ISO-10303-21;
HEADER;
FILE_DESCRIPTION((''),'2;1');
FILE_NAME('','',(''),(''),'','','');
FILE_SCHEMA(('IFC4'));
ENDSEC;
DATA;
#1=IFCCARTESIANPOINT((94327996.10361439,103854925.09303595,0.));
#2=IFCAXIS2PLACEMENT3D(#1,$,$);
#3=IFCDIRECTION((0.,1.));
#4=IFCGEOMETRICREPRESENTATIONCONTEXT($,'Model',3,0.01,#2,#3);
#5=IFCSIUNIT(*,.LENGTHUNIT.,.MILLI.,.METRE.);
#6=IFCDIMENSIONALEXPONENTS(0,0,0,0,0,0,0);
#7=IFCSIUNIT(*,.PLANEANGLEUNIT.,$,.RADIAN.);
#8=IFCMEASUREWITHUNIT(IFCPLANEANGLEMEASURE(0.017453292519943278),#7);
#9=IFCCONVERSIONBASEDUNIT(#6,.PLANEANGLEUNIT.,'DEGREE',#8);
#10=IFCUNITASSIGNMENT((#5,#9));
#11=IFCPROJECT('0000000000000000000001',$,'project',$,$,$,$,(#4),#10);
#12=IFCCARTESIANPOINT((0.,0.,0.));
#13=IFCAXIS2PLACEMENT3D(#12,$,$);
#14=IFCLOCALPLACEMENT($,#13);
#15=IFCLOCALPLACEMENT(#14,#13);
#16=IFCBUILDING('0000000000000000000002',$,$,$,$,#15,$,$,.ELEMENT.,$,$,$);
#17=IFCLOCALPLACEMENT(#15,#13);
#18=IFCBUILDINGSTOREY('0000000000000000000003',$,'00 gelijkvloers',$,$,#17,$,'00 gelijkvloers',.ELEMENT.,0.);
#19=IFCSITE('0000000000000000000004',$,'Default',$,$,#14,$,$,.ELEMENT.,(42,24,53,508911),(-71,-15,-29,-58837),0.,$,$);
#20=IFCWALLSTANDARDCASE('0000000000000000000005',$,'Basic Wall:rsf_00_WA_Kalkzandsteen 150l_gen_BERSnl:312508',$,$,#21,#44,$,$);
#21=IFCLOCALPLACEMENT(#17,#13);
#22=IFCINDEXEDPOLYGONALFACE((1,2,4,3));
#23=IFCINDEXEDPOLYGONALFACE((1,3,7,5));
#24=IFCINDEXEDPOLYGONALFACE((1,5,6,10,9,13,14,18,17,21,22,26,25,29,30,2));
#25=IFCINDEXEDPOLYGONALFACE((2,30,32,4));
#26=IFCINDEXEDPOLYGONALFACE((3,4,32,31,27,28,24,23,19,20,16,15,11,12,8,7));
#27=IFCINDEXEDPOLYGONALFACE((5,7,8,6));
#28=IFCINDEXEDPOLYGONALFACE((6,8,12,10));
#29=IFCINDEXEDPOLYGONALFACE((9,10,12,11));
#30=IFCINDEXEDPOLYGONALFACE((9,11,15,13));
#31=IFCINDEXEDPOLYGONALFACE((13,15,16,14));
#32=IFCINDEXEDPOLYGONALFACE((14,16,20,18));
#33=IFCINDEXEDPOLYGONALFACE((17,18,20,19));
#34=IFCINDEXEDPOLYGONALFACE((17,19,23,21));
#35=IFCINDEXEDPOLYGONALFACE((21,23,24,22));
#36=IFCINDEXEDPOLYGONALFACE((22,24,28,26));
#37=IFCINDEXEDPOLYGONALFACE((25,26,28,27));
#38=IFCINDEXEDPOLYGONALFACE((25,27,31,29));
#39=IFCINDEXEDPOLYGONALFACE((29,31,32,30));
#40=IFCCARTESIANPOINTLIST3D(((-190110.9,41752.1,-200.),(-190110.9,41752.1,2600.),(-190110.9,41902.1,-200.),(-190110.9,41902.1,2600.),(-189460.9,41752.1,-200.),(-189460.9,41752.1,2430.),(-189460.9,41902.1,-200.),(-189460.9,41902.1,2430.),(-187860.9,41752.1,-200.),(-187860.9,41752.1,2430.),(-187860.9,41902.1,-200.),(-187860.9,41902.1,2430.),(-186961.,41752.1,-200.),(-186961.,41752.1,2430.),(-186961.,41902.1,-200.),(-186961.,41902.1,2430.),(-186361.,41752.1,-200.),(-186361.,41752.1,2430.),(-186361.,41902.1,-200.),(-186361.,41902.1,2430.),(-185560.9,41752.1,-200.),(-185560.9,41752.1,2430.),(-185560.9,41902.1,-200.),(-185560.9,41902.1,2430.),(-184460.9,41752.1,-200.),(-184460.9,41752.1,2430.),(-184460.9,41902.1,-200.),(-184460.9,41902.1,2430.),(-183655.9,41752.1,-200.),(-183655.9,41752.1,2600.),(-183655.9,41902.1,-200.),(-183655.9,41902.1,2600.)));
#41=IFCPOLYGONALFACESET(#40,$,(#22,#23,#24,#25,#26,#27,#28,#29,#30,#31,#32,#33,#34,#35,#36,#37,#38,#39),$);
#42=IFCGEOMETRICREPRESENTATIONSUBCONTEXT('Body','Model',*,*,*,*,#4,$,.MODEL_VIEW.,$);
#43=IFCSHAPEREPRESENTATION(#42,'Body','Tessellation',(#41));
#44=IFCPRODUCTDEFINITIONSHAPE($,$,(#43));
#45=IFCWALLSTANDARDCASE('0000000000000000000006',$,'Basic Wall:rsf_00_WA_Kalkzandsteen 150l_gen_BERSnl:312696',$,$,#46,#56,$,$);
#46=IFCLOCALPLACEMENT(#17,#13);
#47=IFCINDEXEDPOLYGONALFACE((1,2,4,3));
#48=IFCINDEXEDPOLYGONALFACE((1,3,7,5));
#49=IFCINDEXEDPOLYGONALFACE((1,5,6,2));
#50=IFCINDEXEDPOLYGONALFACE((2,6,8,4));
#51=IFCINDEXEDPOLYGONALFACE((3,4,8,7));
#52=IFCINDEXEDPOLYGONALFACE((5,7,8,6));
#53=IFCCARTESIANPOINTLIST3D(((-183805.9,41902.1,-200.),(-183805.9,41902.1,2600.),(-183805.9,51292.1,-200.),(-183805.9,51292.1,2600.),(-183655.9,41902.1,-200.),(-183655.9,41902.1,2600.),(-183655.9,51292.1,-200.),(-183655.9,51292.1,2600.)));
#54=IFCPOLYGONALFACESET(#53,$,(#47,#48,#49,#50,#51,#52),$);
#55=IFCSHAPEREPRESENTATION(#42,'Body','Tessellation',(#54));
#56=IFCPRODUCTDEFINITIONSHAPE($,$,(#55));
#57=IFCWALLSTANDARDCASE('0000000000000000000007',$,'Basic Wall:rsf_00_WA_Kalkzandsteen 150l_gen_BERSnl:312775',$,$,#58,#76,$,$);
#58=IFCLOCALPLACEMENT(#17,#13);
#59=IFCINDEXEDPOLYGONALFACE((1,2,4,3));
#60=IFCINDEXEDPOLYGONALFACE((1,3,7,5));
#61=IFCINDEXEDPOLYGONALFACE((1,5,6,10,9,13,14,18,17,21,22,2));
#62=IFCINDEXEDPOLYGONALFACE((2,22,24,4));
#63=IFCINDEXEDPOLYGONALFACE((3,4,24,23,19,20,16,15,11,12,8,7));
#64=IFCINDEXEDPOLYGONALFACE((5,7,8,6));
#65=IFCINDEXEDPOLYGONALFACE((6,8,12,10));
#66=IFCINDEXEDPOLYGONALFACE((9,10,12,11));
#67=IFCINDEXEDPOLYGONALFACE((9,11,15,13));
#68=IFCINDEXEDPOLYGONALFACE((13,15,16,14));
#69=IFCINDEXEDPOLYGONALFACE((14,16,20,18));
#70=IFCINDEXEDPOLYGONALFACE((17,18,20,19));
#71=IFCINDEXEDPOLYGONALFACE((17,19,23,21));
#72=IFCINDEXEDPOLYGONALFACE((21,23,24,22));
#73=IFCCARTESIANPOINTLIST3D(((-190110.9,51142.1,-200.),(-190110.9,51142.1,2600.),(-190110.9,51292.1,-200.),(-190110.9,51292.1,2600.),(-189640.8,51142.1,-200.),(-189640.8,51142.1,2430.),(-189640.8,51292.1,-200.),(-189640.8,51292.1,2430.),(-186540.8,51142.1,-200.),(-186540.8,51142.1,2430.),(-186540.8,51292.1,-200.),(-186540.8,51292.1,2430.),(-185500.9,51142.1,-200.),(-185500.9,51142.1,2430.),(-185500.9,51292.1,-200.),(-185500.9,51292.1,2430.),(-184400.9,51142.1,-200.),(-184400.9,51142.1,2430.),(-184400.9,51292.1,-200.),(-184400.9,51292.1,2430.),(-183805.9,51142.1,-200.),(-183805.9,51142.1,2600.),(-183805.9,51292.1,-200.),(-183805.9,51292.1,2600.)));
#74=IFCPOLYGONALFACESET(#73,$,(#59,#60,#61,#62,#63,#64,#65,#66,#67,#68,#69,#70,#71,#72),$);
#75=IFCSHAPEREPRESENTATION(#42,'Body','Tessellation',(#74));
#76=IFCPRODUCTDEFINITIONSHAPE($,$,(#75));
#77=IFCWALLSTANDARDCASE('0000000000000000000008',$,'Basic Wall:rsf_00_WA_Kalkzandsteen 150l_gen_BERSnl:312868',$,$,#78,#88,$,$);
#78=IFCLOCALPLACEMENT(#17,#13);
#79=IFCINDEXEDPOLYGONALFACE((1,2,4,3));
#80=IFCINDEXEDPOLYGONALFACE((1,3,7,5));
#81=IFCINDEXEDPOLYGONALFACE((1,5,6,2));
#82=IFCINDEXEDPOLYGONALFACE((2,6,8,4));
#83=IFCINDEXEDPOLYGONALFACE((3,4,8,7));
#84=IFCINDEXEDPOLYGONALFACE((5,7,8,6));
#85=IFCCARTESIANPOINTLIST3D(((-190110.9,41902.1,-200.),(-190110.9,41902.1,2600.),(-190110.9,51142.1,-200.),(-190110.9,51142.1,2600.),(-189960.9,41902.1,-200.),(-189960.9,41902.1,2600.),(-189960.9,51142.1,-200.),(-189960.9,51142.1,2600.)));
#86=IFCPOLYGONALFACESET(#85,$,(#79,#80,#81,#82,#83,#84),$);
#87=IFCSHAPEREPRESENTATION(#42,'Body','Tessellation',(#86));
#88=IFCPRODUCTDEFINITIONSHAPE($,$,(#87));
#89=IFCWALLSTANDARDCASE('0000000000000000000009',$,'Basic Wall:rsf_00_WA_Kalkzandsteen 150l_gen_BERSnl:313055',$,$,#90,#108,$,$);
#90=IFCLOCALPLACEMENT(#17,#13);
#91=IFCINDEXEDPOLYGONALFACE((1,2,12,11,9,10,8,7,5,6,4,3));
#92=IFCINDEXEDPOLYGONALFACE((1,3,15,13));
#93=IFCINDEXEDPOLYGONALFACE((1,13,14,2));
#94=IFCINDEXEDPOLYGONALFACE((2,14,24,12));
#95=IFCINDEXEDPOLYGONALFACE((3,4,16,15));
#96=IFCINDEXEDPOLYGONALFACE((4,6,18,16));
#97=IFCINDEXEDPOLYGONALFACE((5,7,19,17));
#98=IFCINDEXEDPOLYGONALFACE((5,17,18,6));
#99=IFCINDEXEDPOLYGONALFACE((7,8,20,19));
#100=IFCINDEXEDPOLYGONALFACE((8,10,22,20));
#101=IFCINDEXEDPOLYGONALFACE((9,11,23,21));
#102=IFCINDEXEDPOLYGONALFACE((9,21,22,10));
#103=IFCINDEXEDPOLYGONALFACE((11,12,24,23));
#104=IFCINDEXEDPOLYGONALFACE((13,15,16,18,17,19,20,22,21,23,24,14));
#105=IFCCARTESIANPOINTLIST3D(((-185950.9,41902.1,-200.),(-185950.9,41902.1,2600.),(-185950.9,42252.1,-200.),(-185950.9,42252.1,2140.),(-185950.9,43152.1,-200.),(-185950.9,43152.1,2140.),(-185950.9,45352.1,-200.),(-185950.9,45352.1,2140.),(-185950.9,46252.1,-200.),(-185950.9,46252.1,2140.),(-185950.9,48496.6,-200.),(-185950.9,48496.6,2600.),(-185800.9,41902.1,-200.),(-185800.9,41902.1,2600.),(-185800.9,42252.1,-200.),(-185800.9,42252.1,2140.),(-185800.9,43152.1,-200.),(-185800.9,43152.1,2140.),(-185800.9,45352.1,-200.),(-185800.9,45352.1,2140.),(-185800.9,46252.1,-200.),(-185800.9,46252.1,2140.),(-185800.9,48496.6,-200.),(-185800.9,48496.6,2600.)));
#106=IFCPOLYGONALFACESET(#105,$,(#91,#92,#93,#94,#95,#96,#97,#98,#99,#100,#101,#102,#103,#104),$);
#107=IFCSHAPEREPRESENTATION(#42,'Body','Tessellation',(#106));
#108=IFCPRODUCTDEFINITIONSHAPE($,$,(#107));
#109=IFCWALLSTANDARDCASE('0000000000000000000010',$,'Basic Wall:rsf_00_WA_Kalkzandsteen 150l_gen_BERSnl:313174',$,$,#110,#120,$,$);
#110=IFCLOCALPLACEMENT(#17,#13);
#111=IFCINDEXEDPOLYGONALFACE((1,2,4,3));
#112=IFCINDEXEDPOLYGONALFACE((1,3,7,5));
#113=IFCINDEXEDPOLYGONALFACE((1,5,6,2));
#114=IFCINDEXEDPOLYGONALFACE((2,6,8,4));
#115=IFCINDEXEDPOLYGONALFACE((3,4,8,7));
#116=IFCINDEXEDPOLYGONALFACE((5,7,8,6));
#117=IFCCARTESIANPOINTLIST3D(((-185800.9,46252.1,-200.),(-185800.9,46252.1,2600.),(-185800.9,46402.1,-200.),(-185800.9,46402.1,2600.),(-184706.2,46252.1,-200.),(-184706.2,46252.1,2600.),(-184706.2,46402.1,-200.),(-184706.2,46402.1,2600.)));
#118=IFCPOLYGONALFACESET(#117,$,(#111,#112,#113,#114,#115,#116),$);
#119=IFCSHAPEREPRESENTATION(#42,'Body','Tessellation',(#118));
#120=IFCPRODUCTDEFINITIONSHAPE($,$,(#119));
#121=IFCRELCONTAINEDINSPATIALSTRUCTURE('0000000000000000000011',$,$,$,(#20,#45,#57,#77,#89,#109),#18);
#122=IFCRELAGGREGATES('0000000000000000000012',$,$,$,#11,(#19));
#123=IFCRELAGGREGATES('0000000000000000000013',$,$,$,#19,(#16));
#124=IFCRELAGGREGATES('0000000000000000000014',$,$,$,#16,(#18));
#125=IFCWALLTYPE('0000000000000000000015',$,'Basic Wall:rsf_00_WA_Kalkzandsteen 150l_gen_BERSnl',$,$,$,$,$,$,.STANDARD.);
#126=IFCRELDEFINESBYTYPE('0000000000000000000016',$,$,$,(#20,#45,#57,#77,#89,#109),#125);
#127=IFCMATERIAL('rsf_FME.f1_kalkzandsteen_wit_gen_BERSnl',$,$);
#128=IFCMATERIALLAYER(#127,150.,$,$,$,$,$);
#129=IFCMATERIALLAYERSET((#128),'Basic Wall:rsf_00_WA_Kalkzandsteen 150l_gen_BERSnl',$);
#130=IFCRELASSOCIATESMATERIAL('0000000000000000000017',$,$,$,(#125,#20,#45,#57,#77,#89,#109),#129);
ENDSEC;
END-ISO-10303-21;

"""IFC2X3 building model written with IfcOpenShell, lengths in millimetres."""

from ifc_helpers import new_model, entity, si_unit, converted_unit, direction, frame, frame_2d, origin, place, context, subcontext, project, spatial, polyline, rectangle, extrude, clip, bounded_halfspace, material, layer, layer_set, layer_usage, type_object, element, save


model = new_model("IFC2X3")

# Units and contexts
model_context = context("Model", 3, precision=0.01, world=frame((94327996.10361439, 103854925.09303595, 0.0)), true_north=direction((0.0, 1.0)))
body_context = subcontext(model_context, "Body", "Model", "MODEL_VIEW")
ifc_project = project(units=[si_unit("LENGTHUNIT", "METRE", prefix="MILLI"), converted_unit("PLANEANGLEUNIT", "DEGREE", entity("IfcPlaneAngleMeasure", 0.017453292519943278), si_unit("PLANEANGLEUNIT", "RADIAN"), dimensions=[0, 0, 0, 0, 0, 0, 0])], contexts=[model_context])

# Site, building, storey
site_placement = place(None, origin())
site = spatial("IfcSite", under=ifc_project, at=site_placement, Name="Default", CompositionType="ELEMENT", RefLatitude=(42, 24, 53, 508911), RefLongitude=(-71, -15, -29, -58837), RefElevation=0.0)
building_placement = place(site_placement, origin())
building = spatial("IfcBuilding", under=site, at=building_placement, CompositionType="ELEMENT")
storey_placement = place(building_placement, origin())
storey = spatial("IfcBuildingStorey", under=building, at=storey_placement, Name="00 gelijkvloers", LongName="00 gelijkvloers", CompositionType="ELEMENT", Elevation=0.0)

# Wall, openings
ifc_material_1 = material(Name="rsf_FME.f1_kalkzandsteen_wit_gen_BERSnl")
ifc_layer_1 = layer(ifc_material_1, 150.0)
ifc_layer_set_1 = layer_set([ifc_layer_1], Name="Basic Wall:rsf_00_WA_Kalkzandsteen 150l_gen_BERSnl")
ifc_layer_usage_1 = layer_usage(ifc_layer_set_1, "AXIS2", "POSITIVE", -75.0)
wall_type_1 = type_object("IfcWallType", Name="Basic Wall:rsf_00_WA_Kalkzandsteen 150l_gen_BERSnl", PredefinedType="STANDARD", material=ifc_layer_set_1)
wall_1_placement = place(storey_placement, frame((-190110.9, 41827.1, -200.0)))
wall_1 = element("IfcWallStandardCase", 1, at=wall_1_placement, inside=storey, type_object=wall_type_1, material=ifc_layer_usage_1, Name="Basic Wall:rsf_00_WA_Kalkzandsteen 150l_gen_BERSnl:312508", context=body_context, shape_type="Clipping", body=[
    clip(extrude(rectangle(XDim=6455.0, YDim=150.0, at=frame_2d((3227.5, 0.0), x_axis=(1.0, 0.0))), origin(), (0.0, 0.0, 1.0), 2800.0), bounded_halfspace(frame((0.0, -75.0, 2800.0), z_axis=(0.0, 0.0, -1.0), x_axis=(1.0, 0.0, 0.0)), True, frame((0.0, -75.0, 2800.0)), polyline([(0.0, 0.0), (6455.0, 0.0), (6455.0, 150.0), (6305.0, 150.0), (4310.0, 150.0), (4160.0, 150.0), (150.0, 150.0), (0.0, 150.0), (0.0, 0.0)]))),
])
opening_1_placement = place(wall_1_placement, frame((190110.9, -41827.1, 200.0)))
element("IfcOpeningElement", 2, at=opening_1_placement, cuts=wall_1, ObjectType="Opening", context=body_context, shape_type="SweptSolid", body=[
    extrude(rectangle(XDim=2630.0, YDim=1100.0, at=frame_2d((0.0, 0.0), x_axis=(0.0, 1.0))), frame((-185010.9, 40228.1, 1115.0), z_axis=(0.0, 1.0, 0.0), x_axis=(-1.0, 0.0, 0.0)), (0.0, 0.0, 1.0), 3048.0),
])
opening_2_placement = place(wall_1_placement, frame((190110.9, -41827.1, 200.0)))
element("IfcOpeningElement", 3, at=opening_2_placement, cuts=wall_1, ObjectType="Opening", context=body_context, shape_type="SweptSolid", body=[
    extrude(rectangle(XDim=2630.0, YDim=600.0, at=frame_2d((0.0, 0.0), x_axis=(0.0, 1.0))), frame((-186661.0, 40228.1, 1115.0), z_axis=(0.0, 1.0, 0.0), x_axis=(-1.0, 0.0, 0.0)), (0.0, 0.0, 1.0), 3048.0),
])
opening_3_placement = place(wall_1_placement, frame((190110.9, -41827.1, 200.0)))
element("IfcOpeningElement", 4, at=opening_3_placement, cuts=wall_1, ObjectType="Opening", context=body_context, shape_type="SweptSolid", body=[
    extrude(rectangle(XDim=2630.0, YDim=1600.0, at=frame_2d((0.0, 0.0), x_axis=(0.0, 1.0))), frame((-188660.9, 40228.1, 1115.0), z_axis=(0.0, 1.0, 0.0), x_axis=(-1.0, 0.0, 0.0)), (0.0, 0.0, 1.0), 3048.0),
])

# Wall
ifc_layer_usage_2 = layer_usage(ifc_layer_set_1, "AXIS2", "POSITIVE", -75.0)
wall_2_placement = place(storey_placement, frame((-183730.9, 41902.1, -200.0), z_axis=(0.0, 0.0, 1.0), x_axis=(0.0, 1.0, 0.0)))
element("IfcWallStandardCase", 5, at=wall_2_placement, inside=storey, type_object=wall_type_1, material=ifc_layer_usage_2, Name="Basic Wall:rsf_00_WA_Kalkzandsteen 150l_gen_BERSnl:312696", context=body_context, shape_type="Clipping", body=[
    clip(extrude(rectangle(XDim=9390.0, YDim=150.0, at=frame_2d((4695.0, 0.0), x_axis=(-1.0, 0.0))), origin(), (0.0, 0.0, 1.0), 2800.0), bounded_halfspace(frame((0.0, -75.0, 2800.0), z_axis=(0.0, 0.0, -1.0), x_axis=(0.0, -1.0, 0.0)), True, frame((0.0, -75.0, 2800.0)), polyline([(0.0, 0.0), (9390.0, 0.0), (9390.0, 150.0), (9240.0, 150.0), (0.0, 150.0), (0.0, 0.0)]))),
])

# Wall, openings
ifc_layer_usage_3 = layer_usage(ifc_layer_set_1, "AXIS2", "POSITIVE", -75.0)
wall_3_placement = place(storey_placement, frame((-183805.9, 51217.1, -200.0), z_axis=(0.0, 0.0, 1.0), x_axis=(-1.0, 0.0, 0.0)))
wall_3 = element("IfcWallStandardCase", 6, at=wall_3_placement, inside=storey, type_object=wall_type_1, material=ifc_layer_usage_3, Name="Basic Wall:rsf_00_WA_Kalkzandsteen 150l_gen_BERSnl:312775", context=body_context, shape_type="Clipping", body=[
    clip(extrude(rectangle(XDim=6305.0, YDim=150.0, at=frame_2d((3152.5, 0.0), x_axis=(-1.0, 0.0))), origin(), (0.0, 0.0, 1.0), 2800.0), bounded_halfspace(frame((0.0, -75.0, 2800.0), z_axis=(0.0, 0.0, -1.0), x_axis=(-1.0, 0.0, 0.0)), True, frame((0.0, -75.0, 2800.0)), polyline([(0.0, 0.0), (6305.0, 0.0), (6305.0, 150.0), (6155.0, 150.0), (0.0, 150.0), (0.0, 0.0)]))),
])
opening_4_placement = place(wall_3_placement, frame((-183805.9, 51217.1, 200.0), z_axis=(0.0, 0.0, 1.0), x_axis=(-1.0, 0.0, 0.0)))
element("IfcOpeningElement", 7, at=opening_4_placement, cuts=wall_3, ObjectType="Opening", context=body_context, shape_type="SweptSolid", body=[
    extrude(rectangle(XDim=2630.0, YDim=3100.0, at=frame_2d((0.0, 0.0), x_axis=(0.0, 1.0))), frame((-188090.8, 52816.1, 1115.0), z_axis=(0.0, -1.0, 0.0), x_axis=(1.0, 0.0, 0.0)), (0.0, 0.0, 1.0), 3048.0),
])
opening_5_placement = place(wall_3_placement, frame((-183805.9, 51217.1, 200.0), z_axis=(0.0, 0.0, 1.0), x_axis=(-1.0, 0.0, 0.0)))
element("IfcOpeningElement", 8, at=opening_5_placement, cuts=wall_3, ObjectType="Opening", context=body_context, shape_type="SweptSolid", body=[
    extrude(rectangle(XDim=2630.0, YDim=1100.0, at=frame_2d((0.0, 0.0), x_axis=(0.0, 1.0))), frame((-184950.9, 52816.1, 1115.0), z_axis=(0.0, -1.0, 0.0), x_axis=(1.0, 0.0, 0.0)), (0.0, 0.0, 1.0), 3048.0),
])

# Wall
ifc_layer_usage_4 = layer_usage(ifc_layer_set_1, "AXIS2", "POSITIVE", -75.0)
wall_4_placement = place(storey_placement, frame((-190035.9, 51142.1, -200.0), z_axis=(0.0, 0.0, 1.0), x_axis=(0.0, -1.0, 0.0)))
element("IfcWallStandardCase", 9, at=wall_4_placement, inside=storey, type_object=wall_type_1, material=ifc_layer_usage_4, Name="Basic Wall:rsf_00_WA_Kalkzandsteen 150l_gen_BERSnl:312868", context=body_context, shape_type="Clipping", body=[
    clip(extrude(rectangle(XDim=9240.0, YDim=150.0, at=frame_2d((4620.0, 0.0), x_axis=(-1.0, 0.0))), origin(), (0.0, 0.0, 1.0), 2800.0), bounded_halfspace(frame((0.0, -75.0, 2800.0), z_axis=(0.0, 0.0, -1.0), x_axis=(0.0, 1.0, 0.0)), True, frame((0.0, -75.0, 2800.0)), polyline([(0.0, 0.0), (9240.0, 0.0), (9240.0, 150.0), (0.0, 150.0), (0.0, 0.0)]))),
])

# Wall, openings
ifc_layer_usage_5 = layer_usage(ifc_layer_set_1, "AXIS2", "POSITIVE", -75.0)
wall_5_placement = place(storey_placement, frame((-185875.9, 48496.6, -200.0), z_axis=(0.0, 0.0, 1.0), x_axis=(0.0, -1.0, 0.0)))
wall_5 = element("IfcWallStandardCase", 10, at=wall_5_placement, inside=storey, type_object=wall_type_1, material=ifc_layer_usage_5, Name="Basic Wall:rsf_00_WA_Kalkzandsteen 150l_gen_BERSnl:313055", context=body_context, shape_type="Clipping", body=[
    clip(extrude(rectangle(XDim=6594.5, YDim=150.0, at=frame_2d((3297.3, 0.0), x_axis=(1.0, 0.0))), origin(), (0.0, 0.0, 1.0), 2800.0), bounded_halfspace(frame((0.0, -75.0, 2800.0), z_axis=(0.0, 0.0, -1.0), x_axis=(0.0, 1.0, 0.0)), True, frame((0.0, -75.0, 2800.0)), polyline([(0.0, 0.0), (6594.5, 0.0), (6594.5, 150.0), (2244.5, 150.0), (2094.5, 150.0), (0.0, 150.0), (0.0, 0.0)]))),
])
opening_6_placement = place(wall_5_placement, frame((48496.6, 185875.9, 200.0), z_axis=(0.0, 0.0, 1.0), x_axis=(0.0, 1.0, 0.0)))
element("IfcOpeningElement", 11, at=opening_6_placement, cuts=wall_5, ObjectType="Opening", context=body_context, shape_type="SweptSolid", body=[
    extrude(rectangle(XDim=2340.0, YDim=900.0, at=frame_2d((0.0, 0.0), x_axis=(0.0, 1.0))), frame((-187474.9, 45802.1, 970.0), z_axis=(1.0, 0.0, 0.0), x_axis=(0.0, 1.0, 0.0)), (0.0, 0.0, 1.0), 3048.0),
])
opening_7_placement = place(wall_5_placement, frame((48496.6, 185875.9, 200.0), z_axis=(0.0, 0.0, 1.0), x_axis=(0.0, 1.0, 0.0)))
element("IfcOpeningElement", 12, at=opening_7_placement, cuts=wall_5, ObjectType="Opening", context=body_context, shape_type="SweptSolid", body=[
    extrude(rectangle(XDim=2340.0, YDim=900.0, at=frame_2d((0.0, 0.0), x_axis=(0.0, 1.0))), frame((-187474.9, 42702.1, 970.0), z_axis=(1.0, 0.0, 0.0), x_axis=(0.0, 1.0, 0.0)), (0.0, 0.0, 1.0), 3048.0),
])

# Wall
ifc_layer_usage_6 = layer_usage(ifc_layer_set_1, "AXIS2", "NEGATIVE", 75.0)
wall_6_placement = place(storey_placement, frame((-185800.9, 46327.1, -200.0)))
element("IfcWallStandardCase", 13, at=wall_6_placement, inside=storey, type_object=wall_type_1, material=ifc_layer_usage_6, Name="Basic Wall:rsf_00_WA_Kalkzandsteen 150l_gen_BERSnl:313174", context=body_context, shape_type="Clipping", body=[
    clip(extrude(rectangle(XDim=1094.6, YDim=150.0, at=frame_2d((547.3, 0.0), x_axis=(-1.0, 0.0))), origin(), (0.0, 0.0, 1.0), 2800.0), bounded_halfspace(frame((0.0, -75.0, 2800.0), z_axis=(0.0, 0.0, -1.0), x_axis=(1.0, 0.0, 0.0)), True, frame((0.0, -75.0, 2800.0)), polyline([(0.0, 0.0), (1094.6, 0.0), (1094.6, 150.0), (0.0, 150.0), (0.0, 0.0)]))),
])

save(model, "model.ifc")
